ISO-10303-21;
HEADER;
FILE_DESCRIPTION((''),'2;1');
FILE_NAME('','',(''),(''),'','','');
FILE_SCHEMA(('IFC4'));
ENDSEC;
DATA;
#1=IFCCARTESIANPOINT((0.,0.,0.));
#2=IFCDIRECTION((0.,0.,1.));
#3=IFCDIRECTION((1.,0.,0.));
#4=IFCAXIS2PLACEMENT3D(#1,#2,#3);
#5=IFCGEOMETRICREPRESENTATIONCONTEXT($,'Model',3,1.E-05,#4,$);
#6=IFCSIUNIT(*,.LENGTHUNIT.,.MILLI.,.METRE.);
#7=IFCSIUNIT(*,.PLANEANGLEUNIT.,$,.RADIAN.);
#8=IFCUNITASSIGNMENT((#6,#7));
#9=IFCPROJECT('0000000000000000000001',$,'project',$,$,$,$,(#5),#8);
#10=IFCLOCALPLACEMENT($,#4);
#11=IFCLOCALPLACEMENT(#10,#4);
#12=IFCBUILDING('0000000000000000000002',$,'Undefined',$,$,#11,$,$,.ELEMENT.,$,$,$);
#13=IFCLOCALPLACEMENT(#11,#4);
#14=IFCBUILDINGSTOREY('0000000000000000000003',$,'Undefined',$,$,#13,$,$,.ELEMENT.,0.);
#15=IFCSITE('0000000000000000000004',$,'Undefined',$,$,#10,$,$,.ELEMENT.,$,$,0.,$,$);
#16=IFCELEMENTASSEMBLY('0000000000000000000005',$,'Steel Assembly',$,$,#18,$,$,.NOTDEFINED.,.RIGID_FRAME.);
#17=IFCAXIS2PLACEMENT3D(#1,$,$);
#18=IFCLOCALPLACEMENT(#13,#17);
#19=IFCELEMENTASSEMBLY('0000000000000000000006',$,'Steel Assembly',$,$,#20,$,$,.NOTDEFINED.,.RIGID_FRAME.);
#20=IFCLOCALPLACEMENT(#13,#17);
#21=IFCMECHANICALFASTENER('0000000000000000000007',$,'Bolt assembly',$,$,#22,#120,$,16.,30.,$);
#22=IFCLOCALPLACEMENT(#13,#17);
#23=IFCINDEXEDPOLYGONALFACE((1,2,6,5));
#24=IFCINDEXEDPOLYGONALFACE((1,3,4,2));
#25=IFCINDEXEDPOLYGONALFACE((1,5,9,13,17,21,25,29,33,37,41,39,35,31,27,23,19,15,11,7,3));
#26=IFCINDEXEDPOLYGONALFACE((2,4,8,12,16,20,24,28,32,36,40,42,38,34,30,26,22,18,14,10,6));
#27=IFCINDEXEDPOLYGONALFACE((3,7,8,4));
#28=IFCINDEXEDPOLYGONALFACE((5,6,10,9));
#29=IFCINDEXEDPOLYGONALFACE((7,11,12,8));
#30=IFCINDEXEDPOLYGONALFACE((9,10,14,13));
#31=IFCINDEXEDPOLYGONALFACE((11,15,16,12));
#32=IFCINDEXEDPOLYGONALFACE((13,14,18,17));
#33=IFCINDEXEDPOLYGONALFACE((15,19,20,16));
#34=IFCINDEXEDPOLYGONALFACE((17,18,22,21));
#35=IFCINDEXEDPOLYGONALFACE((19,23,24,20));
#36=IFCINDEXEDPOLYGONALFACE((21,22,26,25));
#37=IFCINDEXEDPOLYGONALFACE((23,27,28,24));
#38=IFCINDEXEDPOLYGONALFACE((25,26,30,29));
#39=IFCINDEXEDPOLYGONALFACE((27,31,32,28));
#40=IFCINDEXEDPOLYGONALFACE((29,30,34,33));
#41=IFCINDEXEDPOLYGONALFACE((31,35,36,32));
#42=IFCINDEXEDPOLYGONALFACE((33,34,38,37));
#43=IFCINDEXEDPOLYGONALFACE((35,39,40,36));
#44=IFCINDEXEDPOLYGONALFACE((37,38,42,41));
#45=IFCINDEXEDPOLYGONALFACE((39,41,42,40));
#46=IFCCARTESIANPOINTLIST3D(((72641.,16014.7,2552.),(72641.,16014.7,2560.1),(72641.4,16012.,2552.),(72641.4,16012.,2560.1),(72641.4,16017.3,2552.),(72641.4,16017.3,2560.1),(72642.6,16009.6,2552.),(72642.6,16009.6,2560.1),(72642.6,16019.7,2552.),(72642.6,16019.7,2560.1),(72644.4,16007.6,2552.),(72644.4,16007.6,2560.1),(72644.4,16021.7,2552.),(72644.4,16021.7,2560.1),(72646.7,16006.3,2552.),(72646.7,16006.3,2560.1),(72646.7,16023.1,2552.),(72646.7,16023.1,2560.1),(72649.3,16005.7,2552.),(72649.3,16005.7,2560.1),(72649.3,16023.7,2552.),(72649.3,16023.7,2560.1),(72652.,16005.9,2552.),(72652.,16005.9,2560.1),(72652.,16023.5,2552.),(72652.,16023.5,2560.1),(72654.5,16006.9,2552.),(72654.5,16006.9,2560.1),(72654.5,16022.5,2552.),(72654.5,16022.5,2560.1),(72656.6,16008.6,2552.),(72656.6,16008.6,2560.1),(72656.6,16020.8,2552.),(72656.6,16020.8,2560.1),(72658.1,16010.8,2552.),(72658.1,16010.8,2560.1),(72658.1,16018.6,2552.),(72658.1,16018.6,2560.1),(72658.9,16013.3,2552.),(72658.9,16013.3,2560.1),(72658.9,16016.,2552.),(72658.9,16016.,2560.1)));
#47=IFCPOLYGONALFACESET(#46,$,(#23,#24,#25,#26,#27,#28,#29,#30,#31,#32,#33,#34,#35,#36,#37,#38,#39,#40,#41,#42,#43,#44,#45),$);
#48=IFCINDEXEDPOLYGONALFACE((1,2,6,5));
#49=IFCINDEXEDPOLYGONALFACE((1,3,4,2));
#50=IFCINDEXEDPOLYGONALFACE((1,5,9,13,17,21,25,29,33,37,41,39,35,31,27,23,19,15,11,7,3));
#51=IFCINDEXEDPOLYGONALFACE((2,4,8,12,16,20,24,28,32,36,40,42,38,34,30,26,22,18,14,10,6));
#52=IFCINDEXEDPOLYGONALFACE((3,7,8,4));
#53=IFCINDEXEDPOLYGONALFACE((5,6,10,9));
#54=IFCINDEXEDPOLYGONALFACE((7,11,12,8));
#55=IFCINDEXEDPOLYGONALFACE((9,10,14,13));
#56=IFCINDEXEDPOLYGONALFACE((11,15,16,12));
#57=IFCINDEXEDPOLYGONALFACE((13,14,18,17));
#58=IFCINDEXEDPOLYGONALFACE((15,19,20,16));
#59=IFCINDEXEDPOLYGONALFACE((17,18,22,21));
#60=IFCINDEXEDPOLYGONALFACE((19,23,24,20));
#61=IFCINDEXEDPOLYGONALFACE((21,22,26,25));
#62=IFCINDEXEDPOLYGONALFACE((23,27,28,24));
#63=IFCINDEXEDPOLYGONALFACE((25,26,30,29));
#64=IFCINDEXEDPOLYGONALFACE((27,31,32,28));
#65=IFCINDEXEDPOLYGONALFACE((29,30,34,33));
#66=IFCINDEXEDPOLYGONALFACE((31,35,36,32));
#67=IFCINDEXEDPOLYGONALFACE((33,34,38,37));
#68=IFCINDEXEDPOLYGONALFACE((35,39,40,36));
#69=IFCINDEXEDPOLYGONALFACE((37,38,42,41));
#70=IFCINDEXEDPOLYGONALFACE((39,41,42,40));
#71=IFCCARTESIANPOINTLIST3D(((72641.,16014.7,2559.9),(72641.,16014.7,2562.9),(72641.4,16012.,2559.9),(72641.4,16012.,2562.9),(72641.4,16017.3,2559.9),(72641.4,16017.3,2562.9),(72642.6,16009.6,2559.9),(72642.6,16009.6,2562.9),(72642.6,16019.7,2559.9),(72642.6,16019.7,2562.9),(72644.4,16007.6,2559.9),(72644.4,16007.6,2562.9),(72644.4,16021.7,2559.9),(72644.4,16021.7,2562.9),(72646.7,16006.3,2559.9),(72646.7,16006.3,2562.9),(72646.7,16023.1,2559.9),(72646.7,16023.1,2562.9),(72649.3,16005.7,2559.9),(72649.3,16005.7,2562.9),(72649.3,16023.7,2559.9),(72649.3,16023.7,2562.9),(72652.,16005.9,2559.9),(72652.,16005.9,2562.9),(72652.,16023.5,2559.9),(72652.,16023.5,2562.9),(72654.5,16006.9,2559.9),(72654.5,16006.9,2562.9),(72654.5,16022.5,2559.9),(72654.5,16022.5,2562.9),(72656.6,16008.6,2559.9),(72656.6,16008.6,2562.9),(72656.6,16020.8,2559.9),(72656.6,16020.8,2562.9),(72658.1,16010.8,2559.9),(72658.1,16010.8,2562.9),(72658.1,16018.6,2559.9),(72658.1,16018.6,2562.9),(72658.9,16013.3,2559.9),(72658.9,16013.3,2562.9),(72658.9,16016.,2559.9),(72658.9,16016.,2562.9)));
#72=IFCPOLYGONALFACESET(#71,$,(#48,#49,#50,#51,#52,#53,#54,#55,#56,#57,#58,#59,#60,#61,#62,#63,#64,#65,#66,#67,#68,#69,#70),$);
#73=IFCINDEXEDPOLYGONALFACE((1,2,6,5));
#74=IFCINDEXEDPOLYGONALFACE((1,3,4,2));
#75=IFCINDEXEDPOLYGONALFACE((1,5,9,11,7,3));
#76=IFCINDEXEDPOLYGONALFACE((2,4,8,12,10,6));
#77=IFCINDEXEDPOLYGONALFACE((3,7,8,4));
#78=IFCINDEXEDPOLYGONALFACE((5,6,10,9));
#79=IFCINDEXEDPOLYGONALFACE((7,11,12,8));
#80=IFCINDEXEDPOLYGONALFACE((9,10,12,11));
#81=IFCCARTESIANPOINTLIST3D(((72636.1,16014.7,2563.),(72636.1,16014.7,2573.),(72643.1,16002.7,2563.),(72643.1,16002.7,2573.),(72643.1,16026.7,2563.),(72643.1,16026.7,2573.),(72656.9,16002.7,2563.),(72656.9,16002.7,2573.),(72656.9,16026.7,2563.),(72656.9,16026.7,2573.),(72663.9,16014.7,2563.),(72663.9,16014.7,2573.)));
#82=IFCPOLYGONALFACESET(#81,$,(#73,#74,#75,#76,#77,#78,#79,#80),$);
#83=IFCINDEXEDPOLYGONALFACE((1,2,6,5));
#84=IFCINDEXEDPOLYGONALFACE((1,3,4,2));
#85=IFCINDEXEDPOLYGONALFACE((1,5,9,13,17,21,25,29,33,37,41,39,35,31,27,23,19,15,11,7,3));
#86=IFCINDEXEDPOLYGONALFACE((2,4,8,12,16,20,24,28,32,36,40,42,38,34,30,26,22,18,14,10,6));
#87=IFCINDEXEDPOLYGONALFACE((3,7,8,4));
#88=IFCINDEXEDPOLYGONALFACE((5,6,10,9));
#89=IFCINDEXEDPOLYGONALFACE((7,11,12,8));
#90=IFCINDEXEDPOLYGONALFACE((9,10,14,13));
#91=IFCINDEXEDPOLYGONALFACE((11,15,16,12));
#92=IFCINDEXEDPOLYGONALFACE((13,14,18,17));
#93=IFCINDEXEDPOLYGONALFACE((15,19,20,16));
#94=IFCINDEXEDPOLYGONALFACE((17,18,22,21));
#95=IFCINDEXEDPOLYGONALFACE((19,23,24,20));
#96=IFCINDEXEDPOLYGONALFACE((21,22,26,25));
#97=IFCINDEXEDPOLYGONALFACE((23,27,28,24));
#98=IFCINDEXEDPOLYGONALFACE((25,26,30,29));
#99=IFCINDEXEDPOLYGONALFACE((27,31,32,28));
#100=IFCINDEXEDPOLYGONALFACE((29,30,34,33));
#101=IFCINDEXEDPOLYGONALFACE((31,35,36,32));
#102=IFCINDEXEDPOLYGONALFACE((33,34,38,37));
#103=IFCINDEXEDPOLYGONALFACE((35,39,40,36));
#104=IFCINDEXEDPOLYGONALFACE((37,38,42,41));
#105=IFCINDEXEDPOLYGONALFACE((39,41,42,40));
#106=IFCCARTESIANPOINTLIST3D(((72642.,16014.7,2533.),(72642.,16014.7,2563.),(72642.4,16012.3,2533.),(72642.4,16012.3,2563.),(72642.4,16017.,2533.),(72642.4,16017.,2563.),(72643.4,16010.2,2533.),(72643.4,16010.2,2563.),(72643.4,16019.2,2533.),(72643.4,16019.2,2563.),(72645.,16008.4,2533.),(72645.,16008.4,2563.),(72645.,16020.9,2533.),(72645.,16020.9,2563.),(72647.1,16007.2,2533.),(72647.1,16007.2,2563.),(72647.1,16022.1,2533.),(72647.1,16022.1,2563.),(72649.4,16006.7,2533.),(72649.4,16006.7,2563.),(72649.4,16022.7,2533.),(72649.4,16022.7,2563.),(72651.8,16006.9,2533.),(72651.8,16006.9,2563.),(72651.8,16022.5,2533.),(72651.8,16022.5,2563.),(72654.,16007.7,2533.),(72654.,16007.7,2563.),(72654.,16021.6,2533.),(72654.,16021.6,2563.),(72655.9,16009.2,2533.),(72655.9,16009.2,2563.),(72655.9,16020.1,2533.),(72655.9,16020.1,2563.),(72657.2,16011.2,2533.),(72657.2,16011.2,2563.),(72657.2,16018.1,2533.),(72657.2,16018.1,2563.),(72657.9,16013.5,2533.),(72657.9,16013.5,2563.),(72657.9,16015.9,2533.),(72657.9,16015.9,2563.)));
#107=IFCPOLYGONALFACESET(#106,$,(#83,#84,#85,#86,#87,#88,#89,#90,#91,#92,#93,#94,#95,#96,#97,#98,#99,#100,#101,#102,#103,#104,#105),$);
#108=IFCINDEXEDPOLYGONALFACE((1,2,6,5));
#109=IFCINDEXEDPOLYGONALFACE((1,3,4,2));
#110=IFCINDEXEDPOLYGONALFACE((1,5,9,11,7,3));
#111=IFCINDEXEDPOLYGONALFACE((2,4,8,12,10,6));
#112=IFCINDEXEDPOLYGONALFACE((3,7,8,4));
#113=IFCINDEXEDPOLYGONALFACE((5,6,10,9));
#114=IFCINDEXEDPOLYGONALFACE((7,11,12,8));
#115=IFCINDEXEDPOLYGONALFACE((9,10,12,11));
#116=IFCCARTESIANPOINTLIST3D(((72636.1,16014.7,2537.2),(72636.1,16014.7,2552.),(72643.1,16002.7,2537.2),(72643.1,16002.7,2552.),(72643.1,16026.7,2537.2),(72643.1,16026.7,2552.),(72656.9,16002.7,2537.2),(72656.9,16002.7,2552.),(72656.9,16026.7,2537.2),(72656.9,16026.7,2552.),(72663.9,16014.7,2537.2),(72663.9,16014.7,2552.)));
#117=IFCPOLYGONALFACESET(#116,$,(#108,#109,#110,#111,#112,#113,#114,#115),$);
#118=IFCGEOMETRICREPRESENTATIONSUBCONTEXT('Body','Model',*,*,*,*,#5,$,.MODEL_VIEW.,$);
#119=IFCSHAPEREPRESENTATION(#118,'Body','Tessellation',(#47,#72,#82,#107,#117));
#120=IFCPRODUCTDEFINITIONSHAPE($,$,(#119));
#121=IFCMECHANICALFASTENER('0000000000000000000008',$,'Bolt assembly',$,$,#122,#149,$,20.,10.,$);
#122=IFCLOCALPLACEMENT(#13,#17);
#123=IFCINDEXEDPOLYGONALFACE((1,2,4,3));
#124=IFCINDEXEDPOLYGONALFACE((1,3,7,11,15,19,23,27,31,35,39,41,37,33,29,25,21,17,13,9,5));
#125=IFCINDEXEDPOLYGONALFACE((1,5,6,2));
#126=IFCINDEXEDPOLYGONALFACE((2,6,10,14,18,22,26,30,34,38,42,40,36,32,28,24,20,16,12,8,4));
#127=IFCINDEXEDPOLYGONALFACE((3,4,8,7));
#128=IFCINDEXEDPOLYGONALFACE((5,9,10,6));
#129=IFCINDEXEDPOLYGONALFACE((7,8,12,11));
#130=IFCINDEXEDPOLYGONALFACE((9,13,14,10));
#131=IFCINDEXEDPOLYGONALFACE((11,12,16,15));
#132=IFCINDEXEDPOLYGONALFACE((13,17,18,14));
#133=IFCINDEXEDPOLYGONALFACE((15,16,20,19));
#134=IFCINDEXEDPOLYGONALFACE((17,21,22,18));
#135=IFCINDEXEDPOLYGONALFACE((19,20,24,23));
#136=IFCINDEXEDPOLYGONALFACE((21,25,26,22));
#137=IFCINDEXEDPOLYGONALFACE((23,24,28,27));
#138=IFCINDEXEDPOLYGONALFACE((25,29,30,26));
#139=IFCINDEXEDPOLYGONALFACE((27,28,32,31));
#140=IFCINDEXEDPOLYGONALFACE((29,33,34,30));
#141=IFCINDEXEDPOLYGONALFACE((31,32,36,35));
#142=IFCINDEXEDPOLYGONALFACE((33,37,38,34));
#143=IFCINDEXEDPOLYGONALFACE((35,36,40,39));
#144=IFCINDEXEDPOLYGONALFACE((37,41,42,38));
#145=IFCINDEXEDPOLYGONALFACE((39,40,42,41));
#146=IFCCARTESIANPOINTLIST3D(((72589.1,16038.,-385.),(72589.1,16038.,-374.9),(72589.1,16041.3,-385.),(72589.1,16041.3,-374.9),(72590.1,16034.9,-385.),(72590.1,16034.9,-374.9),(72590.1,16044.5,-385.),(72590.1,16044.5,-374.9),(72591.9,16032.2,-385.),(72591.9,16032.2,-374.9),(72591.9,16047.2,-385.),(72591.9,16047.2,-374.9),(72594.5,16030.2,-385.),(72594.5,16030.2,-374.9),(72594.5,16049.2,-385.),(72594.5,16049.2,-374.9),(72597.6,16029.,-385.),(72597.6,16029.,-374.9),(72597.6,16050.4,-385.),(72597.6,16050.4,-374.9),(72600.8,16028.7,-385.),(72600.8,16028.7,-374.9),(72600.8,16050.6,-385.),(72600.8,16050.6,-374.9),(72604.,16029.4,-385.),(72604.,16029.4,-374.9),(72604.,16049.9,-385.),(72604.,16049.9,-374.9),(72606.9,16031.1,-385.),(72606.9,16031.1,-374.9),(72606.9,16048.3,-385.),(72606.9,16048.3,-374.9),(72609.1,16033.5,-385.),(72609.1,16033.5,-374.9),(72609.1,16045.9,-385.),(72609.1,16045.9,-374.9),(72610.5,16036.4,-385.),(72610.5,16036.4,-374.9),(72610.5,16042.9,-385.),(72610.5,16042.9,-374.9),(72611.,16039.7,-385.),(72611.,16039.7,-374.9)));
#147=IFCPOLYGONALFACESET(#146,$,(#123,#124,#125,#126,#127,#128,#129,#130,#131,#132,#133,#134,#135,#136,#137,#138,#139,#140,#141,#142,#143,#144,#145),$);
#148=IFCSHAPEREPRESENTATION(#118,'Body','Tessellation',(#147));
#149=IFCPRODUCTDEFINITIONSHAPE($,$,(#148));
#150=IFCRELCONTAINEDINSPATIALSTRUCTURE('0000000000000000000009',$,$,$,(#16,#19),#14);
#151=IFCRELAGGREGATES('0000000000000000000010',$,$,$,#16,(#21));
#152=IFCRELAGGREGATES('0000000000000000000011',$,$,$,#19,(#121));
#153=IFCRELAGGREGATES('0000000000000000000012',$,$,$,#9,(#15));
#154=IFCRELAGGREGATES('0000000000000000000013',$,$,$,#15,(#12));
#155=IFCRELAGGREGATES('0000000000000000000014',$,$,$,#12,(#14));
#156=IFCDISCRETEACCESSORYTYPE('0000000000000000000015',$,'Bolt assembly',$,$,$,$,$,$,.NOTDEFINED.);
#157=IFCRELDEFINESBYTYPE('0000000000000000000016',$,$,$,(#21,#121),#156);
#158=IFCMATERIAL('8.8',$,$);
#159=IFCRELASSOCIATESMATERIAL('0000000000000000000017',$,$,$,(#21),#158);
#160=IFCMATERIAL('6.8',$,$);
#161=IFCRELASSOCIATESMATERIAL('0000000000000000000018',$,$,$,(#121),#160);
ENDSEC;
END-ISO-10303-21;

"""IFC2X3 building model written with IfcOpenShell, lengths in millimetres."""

from ifc_helpers import new_model, si_unit, frame, origin_with_axes, origin_2d_with_axis, place, context, subcontext, project, spatial, polyline, circle, outline, extrude, source, transform, mapped, material, type_object, element, aggregate, save


model = new_model("IFC2X3")

# Units and contexts
model_context = context("Model", 3, precision=1e-05, world=origin_with_axes())
body_context = subcontext(model_context, "Body", "Model", "MODEL_VIEW")
ifc_project = project(units=[si_unit("LENGTHUNIT", "METRE", prefix="MILLI"), si_unit("PLANEANGLEUNIT", "RADIAN")], contexts=[model_context])

# Site, building, storey
site_placement = place(None, origin_with_axes())
site = spatial("IfcSite", under=ifc_project, at=site_placement, Name="Undefined", CompositionType="ELEMENT", RefElevation=0.0)
building_placement = place(site_placement, origin_with_axes())
building = spatial("IfcBuilding", under=site, at=building_placement, Name="Undefined", CompositionType="ELEMENT")
storey_placement = place(building_placement, origin_with_axes())
storey = spatial("IfcBuildingStorey", under=building, at=storey_placement, Name="Undefined", CompositionType="ELEMENT", Elevation=0.0)

# Element assembly
assembly_1_placement = place(storey_placement, origin_with_axes())
assembly_1 = element("IfcElementAssembly", 1, at=assembly_1_placement, inside=storey, Name="Steel Assembly", AssemblyPlace="NOTDEFINED", PredefinedType="RIGID_FRAME")

# Element assembly
assembly_2_placement = place(storey_placement, origin_with_axes())
assembly_2 = element("IfcElementAssembly", 2, at=assembly_2_placement, inside=storey, Name="Steel Assembly", AssemblyPlace="NOTDEFINED", PredefinedType="RIGID_FRAME")

# Shared definitions
ifc_material_1 = material(Name="6.8")
discrete_accessory_type_1 = type_object("IfcDiscreteAccessoryType", Name="Bolt assembly")
ifc_material_2 = material(Name="8.8")

# Mechanical fasteners
shared_shape_1 = source(origin_with_axes(), body_context, "Body", "SweptSolid", [
    extrude(circle(Radius=9.0, at=origin_2d_with_axis()), frame((0.0, -0.1, 0.0), z_axis=(0.0, 1.0, 0.0), x_axis=(1.0, 0.0, 0.0)), (0.0, 0.0, 1.0), 8.1),
    extrude(circle(Radius=9.0, at=origin_2d_with_axis()), frame((0.0, -2.9, 0.0), z_axis=(0.0, 1.0, 0.0), x_axis=(1.0, 0.0, 0.0)), (0.0, 0.0, 1.0), 3.0),
    extrude(outline(polyline([(13.9, 0.0), (6.9, 12.0), (-6.9, 12.0), (-13.9, 0.0), (-6.9, -12.0), (6.9, -12.0), (13.9, 0.0)])), frame((0.0, -13.0, 0.0), z_axis=(0.0, 1.0, 0.0), x_axis=(1.0, 0.0, 0.0)), (0.0, 0.0, 1.0), 10.0),
    extrude(circle(Radius=8.0, at=origin_2d_with_axis()), frame((0.0, -3.0, 0.0), z_axis=(0.0, 1.0, 0.0), x_axis=(1.0, 0.0, 0.0)), (0.0, 0.0, 1.0), 30.0),
    extrude(outline(polyline([(13.9, 0.0), (6.9, 12.0), (-6.9, 12.0), (-13.9, 0.0), (-6.9, -12.0), (6.9, -12.0), (13.9, 0.0)])), frame((0.0, 8.0, 0.0), z_axis=(0.0, 1.0, 0.0), x_axis=(1.0, 0.0, 0.0)), (0.0, 0.0, 1.0), 14.8),
])
mechanical_fastener_1_placement = place(assembly_1_placement, frame((72650.0, 16014.7, 2560.0), z_axis=(0.0, -1.0, 0.0), x_axis=(-1.0, 0.0, 0.0)))
mechanical_fastener_1 = element("IfcMechanicalFastener", 3, at=mechanical_fastener_1_placement, type_object=discrete_accessory_type_1, material=ifc_material_2, Name="Bolt assembly", NominalDiameter=16.0, NominalLength=30.0, context=body_context, shape_type="MappedRepresentation", body=[
    mapped(shared_shape_1, transform((0.0, 0.0, 0.0))),
])
aggregate(assembly_1, [mechanical_fastener_1])
shared_shape_2 = source(origin_with_axes(), body_context, "Body", "SweptSolid", [
    extrude(circle(Radius=11.0, at=origin_2d_with_axis()), frame((0.0, 0.0, 0.0), z_axis=(0.0, 1.0, 0.0), x_axis=(1.0, 0.0, 0.0)), (0.0, 0.0, 1.0), 10.1),
])
mechanical_fastener_2_placement = place(assembly_2_placement, frame((72600.0, 16039.7, -385.0), z_axis=(0.0, -1.0, 0.0), x_axis=(1.0, 0.0, 0.0)))
mechanical_fastener_2 = element("IfcMechanicalFastener", 4, at=mechanical_fastener_2_placement, type_object=discrete_accessory_type_1, material=ifc_material_1, Name="Bolt assembly", NominalDiameter=20.0, NominalLength=10.0, context=body_context, shape_type="MappedRepresentation", body=[
    mapped(shared_shape_2, transform((0.0, 0.0, 0.0))),
])
aggregate(assembly_2, [mechanical_fastener_2])

save(model, "model.ifc")
